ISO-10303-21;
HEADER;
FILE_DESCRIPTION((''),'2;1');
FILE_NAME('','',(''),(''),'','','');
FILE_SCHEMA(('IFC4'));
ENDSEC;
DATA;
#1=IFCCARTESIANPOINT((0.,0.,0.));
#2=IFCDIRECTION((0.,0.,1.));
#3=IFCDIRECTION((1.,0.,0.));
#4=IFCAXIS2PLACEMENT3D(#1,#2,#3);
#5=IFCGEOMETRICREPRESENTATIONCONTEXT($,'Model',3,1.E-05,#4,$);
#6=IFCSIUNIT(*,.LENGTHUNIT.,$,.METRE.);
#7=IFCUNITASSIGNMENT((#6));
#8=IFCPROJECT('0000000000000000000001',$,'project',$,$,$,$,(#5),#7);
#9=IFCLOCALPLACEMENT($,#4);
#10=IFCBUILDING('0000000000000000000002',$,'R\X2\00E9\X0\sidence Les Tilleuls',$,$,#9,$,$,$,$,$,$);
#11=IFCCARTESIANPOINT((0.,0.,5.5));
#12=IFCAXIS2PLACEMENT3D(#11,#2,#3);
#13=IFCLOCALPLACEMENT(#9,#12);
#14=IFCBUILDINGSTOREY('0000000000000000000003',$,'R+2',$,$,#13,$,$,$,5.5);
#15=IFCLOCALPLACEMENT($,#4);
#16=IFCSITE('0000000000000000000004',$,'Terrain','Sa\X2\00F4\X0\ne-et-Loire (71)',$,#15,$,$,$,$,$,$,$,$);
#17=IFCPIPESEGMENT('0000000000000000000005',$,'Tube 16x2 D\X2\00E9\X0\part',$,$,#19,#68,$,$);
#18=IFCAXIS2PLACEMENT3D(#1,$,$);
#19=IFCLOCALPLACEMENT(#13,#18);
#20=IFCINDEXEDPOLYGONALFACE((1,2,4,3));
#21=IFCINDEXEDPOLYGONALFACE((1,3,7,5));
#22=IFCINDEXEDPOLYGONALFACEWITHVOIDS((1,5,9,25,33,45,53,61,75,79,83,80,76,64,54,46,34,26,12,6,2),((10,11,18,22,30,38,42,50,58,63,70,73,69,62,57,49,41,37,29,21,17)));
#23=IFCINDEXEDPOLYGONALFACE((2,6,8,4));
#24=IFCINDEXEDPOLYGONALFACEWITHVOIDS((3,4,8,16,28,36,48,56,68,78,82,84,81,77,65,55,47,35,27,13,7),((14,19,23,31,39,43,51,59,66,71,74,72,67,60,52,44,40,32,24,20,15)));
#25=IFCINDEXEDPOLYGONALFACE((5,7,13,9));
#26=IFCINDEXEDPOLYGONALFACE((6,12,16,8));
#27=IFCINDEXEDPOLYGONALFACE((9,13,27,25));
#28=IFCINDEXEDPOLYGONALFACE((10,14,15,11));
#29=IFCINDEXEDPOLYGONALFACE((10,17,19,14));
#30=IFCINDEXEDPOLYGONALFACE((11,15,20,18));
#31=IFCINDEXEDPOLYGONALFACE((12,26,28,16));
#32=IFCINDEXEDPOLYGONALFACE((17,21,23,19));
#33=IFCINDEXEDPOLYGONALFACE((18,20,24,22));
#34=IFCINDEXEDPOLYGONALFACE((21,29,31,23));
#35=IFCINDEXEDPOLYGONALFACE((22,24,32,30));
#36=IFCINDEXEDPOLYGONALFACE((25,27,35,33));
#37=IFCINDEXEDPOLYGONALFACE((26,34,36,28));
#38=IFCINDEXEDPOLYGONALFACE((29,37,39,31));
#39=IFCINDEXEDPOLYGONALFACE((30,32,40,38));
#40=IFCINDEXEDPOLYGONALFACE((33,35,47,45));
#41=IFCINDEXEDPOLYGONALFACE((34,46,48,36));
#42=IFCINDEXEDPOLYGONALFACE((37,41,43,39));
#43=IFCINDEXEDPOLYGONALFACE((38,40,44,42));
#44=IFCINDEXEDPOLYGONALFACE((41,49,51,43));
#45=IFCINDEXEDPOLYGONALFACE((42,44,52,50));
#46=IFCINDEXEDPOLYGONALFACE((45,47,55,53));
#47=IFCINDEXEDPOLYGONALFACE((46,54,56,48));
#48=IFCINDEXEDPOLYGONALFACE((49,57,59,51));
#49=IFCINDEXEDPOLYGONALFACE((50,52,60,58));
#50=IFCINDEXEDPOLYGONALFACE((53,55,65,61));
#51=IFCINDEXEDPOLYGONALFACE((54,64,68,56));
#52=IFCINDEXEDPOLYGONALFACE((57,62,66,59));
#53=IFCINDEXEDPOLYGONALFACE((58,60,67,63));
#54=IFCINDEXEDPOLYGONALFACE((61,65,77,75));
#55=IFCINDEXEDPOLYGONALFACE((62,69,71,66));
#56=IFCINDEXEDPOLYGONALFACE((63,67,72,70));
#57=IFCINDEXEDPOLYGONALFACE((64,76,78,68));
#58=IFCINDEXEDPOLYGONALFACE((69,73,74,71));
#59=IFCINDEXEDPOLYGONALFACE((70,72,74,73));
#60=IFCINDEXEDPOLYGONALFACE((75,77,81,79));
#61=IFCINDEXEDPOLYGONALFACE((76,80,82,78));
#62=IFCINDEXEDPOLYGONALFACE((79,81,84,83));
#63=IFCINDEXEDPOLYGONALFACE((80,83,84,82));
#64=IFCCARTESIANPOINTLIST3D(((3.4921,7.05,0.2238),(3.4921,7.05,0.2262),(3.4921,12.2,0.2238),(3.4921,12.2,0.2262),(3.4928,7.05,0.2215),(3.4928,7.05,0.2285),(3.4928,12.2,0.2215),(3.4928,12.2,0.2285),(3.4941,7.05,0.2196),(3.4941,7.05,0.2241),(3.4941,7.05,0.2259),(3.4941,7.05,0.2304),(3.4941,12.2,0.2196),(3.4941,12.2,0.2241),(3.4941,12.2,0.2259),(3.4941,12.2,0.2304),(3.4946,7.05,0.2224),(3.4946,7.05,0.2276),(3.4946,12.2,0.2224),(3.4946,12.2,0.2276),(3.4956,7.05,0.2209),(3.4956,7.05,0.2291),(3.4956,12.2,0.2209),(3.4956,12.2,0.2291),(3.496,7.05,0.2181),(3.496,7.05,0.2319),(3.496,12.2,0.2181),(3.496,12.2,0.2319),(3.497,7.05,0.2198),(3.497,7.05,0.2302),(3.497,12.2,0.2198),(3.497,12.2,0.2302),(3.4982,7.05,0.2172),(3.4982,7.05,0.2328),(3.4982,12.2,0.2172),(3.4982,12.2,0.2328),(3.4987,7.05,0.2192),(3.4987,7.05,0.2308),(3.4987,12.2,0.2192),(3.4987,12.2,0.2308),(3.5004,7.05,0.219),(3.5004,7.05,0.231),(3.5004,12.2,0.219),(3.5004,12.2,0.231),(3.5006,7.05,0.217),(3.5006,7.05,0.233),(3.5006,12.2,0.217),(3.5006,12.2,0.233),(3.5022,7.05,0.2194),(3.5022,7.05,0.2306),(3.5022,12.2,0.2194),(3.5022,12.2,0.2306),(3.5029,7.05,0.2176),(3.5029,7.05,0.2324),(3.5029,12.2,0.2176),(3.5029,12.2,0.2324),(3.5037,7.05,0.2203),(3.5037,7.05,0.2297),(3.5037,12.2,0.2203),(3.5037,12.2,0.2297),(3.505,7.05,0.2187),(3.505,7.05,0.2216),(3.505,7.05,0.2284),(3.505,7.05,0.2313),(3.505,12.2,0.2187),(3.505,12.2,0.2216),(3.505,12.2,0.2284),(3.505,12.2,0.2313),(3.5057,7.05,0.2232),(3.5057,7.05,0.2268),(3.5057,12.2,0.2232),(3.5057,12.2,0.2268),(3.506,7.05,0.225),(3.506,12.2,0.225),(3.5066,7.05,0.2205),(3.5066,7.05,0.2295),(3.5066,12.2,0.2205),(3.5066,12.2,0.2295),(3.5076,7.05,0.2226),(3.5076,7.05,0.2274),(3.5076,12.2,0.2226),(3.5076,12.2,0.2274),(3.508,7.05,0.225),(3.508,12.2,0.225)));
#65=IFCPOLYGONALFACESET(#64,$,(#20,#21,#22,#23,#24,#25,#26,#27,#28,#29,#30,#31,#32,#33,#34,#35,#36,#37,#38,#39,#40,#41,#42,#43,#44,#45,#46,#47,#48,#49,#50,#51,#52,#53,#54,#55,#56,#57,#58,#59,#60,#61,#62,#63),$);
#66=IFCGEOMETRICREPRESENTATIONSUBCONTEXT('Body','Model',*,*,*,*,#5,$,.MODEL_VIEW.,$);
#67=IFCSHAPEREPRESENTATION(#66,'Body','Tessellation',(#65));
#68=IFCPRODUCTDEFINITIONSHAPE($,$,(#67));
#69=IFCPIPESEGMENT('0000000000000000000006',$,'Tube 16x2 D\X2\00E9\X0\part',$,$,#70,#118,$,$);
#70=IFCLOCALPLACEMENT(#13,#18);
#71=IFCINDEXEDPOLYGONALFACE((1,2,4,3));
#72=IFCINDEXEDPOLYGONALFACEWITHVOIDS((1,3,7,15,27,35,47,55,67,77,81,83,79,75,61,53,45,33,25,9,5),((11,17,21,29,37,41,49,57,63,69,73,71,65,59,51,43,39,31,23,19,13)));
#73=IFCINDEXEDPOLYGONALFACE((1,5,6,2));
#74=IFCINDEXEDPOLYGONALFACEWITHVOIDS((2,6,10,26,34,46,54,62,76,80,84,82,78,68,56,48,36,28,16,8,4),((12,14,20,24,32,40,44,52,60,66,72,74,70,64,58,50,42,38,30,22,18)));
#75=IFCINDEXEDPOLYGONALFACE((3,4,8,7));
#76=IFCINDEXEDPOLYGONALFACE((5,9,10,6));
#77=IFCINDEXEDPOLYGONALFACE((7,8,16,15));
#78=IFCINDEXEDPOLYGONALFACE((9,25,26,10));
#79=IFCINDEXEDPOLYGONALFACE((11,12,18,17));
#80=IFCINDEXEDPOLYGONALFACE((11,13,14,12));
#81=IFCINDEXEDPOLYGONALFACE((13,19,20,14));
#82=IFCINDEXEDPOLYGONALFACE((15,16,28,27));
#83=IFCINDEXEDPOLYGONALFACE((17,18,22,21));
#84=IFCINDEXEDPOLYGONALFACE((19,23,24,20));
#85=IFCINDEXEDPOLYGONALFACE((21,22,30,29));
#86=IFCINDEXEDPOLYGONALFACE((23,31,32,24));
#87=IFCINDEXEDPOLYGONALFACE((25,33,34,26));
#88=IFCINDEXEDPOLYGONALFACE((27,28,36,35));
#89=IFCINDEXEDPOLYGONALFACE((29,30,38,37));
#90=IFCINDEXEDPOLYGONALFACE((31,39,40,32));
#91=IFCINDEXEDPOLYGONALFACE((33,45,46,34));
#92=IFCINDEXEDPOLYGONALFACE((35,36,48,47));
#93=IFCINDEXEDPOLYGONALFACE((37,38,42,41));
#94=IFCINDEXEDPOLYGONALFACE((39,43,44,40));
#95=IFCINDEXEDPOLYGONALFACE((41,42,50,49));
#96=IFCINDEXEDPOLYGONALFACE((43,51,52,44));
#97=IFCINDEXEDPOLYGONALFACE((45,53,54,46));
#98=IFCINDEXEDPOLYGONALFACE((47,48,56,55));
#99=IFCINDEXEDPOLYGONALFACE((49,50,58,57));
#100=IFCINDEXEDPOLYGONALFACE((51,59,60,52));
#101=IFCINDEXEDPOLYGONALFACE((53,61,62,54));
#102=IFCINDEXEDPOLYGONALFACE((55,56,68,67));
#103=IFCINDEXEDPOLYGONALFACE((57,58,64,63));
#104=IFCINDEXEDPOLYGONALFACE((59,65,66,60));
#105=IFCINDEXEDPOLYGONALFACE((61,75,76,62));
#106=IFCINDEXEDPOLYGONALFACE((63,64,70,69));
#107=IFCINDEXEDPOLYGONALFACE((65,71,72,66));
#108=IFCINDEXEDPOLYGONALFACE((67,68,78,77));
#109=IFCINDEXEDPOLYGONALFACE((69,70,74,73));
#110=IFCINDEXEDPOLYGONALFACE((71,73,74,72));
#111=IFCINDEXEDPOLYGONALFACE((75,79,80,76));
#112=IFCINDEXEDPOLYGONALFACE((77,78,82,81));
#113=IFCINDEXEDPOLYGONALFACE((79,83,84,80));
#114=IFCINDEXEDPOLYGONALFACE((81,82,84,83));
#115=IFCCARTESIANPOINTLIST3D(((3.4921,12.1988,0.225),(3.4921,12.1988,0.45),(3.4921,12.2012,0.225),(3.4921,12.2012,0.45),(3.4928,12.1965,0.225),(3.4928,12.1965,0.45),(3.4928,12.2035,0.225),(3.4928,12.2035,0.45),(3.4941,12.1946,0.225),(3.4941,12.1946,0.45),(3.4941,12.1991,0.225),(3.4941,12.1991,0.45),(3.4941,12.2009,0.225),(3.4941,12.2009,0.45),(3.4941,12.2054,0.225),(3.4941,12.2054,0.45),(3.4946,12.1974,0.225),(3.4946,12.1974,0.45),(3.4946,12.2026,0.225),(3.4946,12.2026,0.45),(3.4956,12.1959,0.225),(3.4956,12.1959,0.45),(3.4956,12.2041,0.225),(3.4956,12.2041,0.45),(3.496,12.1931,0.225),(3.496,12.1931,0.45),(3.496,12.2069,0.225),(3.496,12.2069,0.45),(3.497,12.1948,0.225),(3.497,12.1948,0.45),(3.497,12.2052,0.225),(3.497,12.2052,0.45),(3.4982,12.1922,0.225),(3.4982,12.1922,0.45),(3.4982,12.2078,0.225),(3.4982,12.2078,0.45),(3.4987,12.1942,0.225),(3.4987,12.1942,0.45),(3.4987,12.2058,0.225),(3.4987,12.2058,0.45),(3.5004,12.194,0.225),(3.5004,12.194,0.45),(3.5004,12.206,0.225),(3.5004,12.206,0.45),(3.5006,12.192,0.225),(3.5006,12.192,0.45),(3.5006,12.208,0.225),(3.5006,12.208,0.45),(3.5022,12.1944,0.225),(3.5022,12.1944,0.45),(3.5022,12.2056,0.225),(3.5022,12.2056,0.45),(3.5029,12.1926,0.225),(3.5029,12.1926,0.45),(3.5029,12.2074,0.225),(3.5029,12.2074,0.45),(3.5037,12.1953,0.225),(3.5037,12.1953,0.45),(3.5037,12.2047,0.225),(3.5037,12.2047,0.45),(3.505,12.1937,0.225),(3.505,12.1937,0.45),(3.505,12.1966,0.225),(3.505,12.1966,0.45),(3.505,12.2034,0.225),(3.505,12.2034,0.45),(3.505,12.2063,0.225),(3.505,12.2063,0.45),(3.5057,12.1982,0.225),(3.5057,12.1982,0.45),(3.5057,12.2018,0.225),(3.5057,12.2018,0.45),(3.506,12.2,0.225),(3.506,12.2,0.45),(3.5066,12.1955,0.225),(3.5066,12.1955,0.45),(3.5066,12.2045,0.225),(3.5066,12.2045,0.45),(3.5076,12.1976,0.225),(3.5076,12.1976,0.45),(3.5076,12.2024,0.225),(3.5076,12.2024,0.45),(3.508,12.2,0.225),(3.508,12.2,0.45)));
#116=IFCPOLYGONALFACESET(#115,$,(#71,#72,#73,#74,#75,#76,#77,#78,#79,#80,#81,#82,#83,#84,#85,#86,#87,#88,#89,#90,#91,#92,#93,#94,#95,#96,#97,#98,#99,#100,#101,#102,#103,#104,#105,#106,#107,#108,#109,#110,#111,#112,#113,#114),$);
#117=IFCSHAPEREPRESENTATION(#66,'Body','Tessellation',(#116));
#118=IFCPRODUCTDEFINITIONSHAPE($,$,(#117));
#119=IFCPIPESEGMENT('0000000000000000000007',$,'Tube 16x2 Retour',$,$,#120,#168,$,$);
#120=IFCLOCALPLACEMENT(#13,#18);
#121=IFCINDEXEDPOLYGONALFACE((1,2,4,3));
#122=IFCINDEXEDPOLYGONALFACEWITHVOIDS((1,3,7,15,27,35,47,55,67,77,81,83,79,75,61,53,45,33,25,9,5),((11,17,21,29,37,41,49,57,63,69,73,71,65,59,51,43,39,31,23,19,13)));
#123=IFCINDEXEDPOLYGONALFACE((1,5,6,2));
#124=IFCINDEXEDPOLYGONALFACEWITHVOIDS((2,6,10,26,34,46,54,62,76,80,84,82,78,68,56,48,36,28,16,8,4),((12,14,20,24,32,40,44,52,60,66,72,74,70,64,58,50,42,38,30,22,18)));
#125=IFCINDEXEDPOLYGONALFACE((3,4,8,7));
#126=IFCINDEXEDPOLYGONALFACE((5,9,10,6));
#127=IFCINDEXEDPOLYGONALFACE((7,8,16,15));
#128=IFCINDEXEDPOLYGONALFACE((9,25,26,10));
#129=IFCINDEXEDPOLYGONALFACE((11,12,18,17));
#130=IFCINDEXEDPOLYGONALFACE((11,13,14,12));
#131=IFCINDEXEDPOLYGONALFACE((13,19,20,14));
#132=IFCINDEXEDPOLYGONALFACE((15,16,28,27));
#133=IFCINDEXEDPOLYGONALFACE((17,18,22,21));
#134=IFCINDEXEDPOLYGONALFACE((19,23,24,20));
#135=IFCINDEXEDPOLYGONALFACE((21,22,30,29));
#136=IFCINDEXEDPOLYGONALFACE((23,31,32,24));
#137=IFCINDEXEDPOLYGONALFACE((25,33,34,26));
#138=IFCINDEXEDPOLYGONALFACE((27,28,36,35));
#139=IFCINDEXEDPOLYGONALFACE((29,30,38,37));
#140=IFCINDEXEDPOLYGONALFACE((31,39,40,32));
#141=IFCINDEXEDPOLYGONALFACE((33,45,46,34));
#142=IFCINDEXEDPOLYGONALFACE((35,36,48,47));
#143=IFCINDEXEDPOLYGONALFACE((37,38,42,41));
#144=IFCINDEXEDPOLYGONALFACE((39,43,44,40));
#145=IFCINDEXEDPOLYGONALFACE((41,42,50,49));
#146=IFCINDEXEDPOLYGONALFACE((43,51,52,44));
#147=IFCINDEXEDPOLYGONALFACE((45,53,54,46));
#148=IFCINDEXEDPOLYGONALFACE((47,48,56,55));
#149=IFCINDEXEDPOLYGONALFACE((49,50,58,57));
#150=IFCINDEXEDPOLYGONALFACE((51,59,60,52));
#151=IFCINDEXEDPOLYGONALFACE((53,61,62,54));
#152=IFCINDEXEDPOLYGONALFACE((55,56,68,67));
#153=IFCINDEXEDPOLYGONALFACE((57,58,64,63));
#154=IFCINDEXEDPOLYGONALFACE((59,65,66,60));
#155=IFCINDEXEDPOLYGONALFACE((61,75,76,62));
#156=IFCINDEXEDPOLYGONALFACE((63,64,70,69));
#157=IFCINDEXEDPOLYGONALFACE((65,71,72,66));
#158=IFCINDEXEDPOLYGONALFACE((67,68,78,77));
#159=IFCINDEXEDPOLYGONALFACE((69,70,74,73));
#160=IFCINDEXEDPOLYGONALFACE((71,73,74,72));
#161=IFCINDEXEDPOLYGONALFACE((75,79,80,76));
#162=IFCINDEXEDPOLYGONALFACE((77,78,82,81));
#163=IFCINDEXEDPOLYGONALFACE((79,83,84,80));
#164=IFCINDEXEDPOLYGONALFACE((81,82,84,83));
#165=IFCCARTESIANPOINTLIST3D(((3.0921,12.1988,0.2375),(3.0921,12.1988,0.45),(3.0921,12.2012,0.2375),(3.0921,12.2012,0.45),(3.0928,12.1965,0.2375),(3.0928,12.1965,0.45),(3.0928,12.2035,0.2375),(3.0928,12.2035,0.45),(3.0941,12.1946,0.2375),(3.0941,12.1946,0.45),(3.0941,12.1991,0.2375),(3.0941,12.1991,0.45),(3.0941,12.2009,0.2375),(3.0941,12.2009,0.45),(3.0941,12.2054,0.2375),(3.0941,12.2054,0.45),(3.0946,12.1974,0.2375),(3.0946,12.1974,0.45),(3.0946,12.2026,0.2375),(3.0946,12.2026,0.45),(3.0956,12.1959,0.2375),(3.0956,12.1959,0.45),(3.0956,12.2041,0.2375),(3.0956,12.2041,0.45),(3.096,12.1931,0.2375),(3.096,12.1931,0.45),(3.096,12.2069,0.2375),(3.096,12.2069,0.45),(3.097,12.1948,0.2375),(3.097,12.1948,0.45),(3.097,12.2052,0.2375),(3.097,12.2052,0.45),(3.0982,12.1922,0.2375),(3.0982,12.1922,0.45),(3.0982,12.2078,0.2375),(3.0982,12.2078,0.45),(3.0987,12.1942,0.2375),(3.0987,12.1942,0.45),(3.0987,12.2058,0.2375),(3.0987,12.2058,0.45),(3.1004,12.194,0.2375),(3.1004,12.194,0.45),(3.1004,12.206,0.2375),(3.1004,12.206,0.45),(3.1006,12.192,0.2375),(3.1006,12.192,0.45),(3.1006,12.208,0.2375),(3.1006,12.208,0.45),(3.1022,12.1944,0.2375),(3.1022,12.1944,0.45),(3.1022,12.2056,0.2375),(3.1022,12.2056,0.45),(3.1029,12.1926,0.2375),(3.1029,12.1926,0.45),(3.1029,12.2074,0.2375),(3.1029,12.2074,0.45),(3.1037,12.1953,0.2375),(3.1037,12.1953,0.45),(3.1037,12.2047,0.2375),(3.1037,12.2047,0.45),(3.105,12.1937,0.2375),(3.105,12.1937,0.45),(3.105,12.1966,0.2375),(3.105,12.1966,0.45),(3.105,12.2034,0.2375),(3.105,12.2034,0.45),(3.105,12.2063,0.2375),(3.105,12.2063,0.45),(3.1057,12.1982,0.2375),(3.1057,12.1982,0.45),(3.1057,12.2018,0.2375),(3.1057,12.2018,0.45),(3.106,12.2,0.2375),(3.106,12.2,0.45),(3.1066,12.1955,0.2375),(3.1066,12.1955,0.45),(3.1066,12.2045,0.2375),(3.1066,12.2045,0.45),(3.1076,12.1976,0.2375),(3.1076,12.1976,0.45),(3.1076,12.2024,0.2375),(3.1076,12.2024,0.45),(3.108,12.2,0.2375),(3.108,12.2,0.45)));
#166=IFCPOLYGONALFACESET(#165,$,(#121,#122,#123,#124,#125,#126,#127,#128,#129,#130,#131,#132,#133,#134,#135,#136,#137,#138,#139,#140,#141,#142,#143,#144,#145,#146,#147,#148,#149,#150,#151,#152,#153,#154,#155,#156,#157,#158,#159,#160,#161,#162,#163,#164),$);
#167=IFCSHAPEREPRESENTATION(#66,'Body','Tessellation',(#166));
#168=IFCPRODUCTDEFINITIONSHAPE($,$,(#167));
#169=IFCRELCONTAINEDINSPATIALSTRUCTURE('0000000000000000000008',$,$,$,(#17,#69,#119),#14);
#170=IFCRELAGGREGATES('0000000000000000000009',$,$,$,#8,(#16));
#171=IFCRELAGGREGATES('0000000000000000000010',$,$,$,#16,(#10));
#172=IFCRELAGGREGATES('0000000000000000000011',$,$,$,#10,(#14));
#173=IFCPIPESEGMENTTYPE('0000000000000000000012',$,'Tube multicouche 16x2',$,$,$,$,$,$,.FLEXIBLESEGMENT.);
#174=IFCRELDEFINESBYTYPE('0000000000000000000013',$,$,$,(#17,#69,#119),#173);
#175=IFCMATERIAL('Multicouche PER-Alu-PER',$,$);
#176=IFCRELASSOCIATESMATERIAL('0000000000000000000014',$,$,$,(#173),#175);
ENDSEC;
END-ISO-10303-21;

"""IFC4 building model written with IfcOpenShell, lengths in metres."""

from ifc_helpers import new_model, si_unit, frame, origin_with_axes, place, context, subcontext, project, spatial, hollow_circle, extrude, material, type_object, element, save


model = new_model("IFC4")

# Units and contexts
model_context = context("Model", 3, precision=1e-05, world=origin_with_axes())
body_context = subcontext(model_context, "Body", "Model", "MODEL_VIEW")
ifc_project = project(units=[si_unit("LENGTHUNIT", "METRE")], contexts=[model_context])

# Site, building, storey
site_placement = place(None, origin_with_axes())
site = spatial("IfcSite", under=ifc_project, at=site_placement, Name="Terrain", Description="Saône-et-Loire (71)")
building_placement = place(None, origin_with_axes())
building = spatial("IfcBuilding", under=site, at=building_placement, Name="Résidence Les Tilleuls")
storey_placement = place(building_placement, frame((0.0, 0.0, 5.5), z_axis=(0.0, 0.0, 1.0), x_axis=(1.0, 0.0, 0.0)))
storey = spatial("IfcBuildingStorey", under=building, at=storey_placement, Name="R+2", Elevation=5.5)

# Pipe segments
ifc_material_1 = material(Name="Multicouche PER-Alu-PER")
pipe_segment_type_1 = type_object("IfcPipeSegmentType", Name="Tube multicouche 16x2", PredefinedType="FLEXIBLESEGMENT", material=ifc_material_1)
pipe_segment_1_placement = place(storey_placement, frame((3.5, 7.05, 0.225), z_axis=(0.0, 1.0, 0.0), x_axis=(1.0, 0.0, 0.0)))
element("IfcPipeSegment", 1, at=pipe_segment_1_placement, inside=storey, type_object=pipe_segment_type_1, Name="Tube 16x2 Départ", context=body_context, shape_type="SweptSolid", body=[
    extrude(hollow_circle(Radius=0.008, WallThickness=0.002), origin_with_axes(), (0.0, 0.0, 1.0), 5.15),
])
pipe_segment_2_placement = place(storey_placement, frame((3.5, 12.2, 0.225), z_axis=(0.0, 0.0, 1.0), x_axis=(1.0, 0.0, 0.0)))
element("IfcPipeSegment", 2, at=pipe_segment_2_placement, inside=storey, type_object=pipe_segment_type_1, Name="Tube 16x2 Départ", context=body_context, shape_type="SweptSolid", body=[
    extrude(hollow_circle(Radius=0.008, WallThickness=0.002), origin_with_axes(), (0.0, 0.0, 1.0), 0.225),
])
pipe_segment_3_placement = place(storey_placement, frame((3.1, 12.2, 0.2375), z_axis=(0.0, 0.0, 1.0), x_axis=(1.0, 0.0, 0.0)))
element("IfcPipeSegment", 3, at=pipe_segment_3_placement, inside=storey, type_object=pipe_segment_type_1, Name="Tube 16x2 Retour", context=body_context, shape_type="SweptSolid", body=[
    extrude(hollow_circle(Radius=0.008, WallThickness=0.002), origin_with_axes(), (0.0, 0.0, 1.0), 0.2125),
])

save(model, "model.ifc")
